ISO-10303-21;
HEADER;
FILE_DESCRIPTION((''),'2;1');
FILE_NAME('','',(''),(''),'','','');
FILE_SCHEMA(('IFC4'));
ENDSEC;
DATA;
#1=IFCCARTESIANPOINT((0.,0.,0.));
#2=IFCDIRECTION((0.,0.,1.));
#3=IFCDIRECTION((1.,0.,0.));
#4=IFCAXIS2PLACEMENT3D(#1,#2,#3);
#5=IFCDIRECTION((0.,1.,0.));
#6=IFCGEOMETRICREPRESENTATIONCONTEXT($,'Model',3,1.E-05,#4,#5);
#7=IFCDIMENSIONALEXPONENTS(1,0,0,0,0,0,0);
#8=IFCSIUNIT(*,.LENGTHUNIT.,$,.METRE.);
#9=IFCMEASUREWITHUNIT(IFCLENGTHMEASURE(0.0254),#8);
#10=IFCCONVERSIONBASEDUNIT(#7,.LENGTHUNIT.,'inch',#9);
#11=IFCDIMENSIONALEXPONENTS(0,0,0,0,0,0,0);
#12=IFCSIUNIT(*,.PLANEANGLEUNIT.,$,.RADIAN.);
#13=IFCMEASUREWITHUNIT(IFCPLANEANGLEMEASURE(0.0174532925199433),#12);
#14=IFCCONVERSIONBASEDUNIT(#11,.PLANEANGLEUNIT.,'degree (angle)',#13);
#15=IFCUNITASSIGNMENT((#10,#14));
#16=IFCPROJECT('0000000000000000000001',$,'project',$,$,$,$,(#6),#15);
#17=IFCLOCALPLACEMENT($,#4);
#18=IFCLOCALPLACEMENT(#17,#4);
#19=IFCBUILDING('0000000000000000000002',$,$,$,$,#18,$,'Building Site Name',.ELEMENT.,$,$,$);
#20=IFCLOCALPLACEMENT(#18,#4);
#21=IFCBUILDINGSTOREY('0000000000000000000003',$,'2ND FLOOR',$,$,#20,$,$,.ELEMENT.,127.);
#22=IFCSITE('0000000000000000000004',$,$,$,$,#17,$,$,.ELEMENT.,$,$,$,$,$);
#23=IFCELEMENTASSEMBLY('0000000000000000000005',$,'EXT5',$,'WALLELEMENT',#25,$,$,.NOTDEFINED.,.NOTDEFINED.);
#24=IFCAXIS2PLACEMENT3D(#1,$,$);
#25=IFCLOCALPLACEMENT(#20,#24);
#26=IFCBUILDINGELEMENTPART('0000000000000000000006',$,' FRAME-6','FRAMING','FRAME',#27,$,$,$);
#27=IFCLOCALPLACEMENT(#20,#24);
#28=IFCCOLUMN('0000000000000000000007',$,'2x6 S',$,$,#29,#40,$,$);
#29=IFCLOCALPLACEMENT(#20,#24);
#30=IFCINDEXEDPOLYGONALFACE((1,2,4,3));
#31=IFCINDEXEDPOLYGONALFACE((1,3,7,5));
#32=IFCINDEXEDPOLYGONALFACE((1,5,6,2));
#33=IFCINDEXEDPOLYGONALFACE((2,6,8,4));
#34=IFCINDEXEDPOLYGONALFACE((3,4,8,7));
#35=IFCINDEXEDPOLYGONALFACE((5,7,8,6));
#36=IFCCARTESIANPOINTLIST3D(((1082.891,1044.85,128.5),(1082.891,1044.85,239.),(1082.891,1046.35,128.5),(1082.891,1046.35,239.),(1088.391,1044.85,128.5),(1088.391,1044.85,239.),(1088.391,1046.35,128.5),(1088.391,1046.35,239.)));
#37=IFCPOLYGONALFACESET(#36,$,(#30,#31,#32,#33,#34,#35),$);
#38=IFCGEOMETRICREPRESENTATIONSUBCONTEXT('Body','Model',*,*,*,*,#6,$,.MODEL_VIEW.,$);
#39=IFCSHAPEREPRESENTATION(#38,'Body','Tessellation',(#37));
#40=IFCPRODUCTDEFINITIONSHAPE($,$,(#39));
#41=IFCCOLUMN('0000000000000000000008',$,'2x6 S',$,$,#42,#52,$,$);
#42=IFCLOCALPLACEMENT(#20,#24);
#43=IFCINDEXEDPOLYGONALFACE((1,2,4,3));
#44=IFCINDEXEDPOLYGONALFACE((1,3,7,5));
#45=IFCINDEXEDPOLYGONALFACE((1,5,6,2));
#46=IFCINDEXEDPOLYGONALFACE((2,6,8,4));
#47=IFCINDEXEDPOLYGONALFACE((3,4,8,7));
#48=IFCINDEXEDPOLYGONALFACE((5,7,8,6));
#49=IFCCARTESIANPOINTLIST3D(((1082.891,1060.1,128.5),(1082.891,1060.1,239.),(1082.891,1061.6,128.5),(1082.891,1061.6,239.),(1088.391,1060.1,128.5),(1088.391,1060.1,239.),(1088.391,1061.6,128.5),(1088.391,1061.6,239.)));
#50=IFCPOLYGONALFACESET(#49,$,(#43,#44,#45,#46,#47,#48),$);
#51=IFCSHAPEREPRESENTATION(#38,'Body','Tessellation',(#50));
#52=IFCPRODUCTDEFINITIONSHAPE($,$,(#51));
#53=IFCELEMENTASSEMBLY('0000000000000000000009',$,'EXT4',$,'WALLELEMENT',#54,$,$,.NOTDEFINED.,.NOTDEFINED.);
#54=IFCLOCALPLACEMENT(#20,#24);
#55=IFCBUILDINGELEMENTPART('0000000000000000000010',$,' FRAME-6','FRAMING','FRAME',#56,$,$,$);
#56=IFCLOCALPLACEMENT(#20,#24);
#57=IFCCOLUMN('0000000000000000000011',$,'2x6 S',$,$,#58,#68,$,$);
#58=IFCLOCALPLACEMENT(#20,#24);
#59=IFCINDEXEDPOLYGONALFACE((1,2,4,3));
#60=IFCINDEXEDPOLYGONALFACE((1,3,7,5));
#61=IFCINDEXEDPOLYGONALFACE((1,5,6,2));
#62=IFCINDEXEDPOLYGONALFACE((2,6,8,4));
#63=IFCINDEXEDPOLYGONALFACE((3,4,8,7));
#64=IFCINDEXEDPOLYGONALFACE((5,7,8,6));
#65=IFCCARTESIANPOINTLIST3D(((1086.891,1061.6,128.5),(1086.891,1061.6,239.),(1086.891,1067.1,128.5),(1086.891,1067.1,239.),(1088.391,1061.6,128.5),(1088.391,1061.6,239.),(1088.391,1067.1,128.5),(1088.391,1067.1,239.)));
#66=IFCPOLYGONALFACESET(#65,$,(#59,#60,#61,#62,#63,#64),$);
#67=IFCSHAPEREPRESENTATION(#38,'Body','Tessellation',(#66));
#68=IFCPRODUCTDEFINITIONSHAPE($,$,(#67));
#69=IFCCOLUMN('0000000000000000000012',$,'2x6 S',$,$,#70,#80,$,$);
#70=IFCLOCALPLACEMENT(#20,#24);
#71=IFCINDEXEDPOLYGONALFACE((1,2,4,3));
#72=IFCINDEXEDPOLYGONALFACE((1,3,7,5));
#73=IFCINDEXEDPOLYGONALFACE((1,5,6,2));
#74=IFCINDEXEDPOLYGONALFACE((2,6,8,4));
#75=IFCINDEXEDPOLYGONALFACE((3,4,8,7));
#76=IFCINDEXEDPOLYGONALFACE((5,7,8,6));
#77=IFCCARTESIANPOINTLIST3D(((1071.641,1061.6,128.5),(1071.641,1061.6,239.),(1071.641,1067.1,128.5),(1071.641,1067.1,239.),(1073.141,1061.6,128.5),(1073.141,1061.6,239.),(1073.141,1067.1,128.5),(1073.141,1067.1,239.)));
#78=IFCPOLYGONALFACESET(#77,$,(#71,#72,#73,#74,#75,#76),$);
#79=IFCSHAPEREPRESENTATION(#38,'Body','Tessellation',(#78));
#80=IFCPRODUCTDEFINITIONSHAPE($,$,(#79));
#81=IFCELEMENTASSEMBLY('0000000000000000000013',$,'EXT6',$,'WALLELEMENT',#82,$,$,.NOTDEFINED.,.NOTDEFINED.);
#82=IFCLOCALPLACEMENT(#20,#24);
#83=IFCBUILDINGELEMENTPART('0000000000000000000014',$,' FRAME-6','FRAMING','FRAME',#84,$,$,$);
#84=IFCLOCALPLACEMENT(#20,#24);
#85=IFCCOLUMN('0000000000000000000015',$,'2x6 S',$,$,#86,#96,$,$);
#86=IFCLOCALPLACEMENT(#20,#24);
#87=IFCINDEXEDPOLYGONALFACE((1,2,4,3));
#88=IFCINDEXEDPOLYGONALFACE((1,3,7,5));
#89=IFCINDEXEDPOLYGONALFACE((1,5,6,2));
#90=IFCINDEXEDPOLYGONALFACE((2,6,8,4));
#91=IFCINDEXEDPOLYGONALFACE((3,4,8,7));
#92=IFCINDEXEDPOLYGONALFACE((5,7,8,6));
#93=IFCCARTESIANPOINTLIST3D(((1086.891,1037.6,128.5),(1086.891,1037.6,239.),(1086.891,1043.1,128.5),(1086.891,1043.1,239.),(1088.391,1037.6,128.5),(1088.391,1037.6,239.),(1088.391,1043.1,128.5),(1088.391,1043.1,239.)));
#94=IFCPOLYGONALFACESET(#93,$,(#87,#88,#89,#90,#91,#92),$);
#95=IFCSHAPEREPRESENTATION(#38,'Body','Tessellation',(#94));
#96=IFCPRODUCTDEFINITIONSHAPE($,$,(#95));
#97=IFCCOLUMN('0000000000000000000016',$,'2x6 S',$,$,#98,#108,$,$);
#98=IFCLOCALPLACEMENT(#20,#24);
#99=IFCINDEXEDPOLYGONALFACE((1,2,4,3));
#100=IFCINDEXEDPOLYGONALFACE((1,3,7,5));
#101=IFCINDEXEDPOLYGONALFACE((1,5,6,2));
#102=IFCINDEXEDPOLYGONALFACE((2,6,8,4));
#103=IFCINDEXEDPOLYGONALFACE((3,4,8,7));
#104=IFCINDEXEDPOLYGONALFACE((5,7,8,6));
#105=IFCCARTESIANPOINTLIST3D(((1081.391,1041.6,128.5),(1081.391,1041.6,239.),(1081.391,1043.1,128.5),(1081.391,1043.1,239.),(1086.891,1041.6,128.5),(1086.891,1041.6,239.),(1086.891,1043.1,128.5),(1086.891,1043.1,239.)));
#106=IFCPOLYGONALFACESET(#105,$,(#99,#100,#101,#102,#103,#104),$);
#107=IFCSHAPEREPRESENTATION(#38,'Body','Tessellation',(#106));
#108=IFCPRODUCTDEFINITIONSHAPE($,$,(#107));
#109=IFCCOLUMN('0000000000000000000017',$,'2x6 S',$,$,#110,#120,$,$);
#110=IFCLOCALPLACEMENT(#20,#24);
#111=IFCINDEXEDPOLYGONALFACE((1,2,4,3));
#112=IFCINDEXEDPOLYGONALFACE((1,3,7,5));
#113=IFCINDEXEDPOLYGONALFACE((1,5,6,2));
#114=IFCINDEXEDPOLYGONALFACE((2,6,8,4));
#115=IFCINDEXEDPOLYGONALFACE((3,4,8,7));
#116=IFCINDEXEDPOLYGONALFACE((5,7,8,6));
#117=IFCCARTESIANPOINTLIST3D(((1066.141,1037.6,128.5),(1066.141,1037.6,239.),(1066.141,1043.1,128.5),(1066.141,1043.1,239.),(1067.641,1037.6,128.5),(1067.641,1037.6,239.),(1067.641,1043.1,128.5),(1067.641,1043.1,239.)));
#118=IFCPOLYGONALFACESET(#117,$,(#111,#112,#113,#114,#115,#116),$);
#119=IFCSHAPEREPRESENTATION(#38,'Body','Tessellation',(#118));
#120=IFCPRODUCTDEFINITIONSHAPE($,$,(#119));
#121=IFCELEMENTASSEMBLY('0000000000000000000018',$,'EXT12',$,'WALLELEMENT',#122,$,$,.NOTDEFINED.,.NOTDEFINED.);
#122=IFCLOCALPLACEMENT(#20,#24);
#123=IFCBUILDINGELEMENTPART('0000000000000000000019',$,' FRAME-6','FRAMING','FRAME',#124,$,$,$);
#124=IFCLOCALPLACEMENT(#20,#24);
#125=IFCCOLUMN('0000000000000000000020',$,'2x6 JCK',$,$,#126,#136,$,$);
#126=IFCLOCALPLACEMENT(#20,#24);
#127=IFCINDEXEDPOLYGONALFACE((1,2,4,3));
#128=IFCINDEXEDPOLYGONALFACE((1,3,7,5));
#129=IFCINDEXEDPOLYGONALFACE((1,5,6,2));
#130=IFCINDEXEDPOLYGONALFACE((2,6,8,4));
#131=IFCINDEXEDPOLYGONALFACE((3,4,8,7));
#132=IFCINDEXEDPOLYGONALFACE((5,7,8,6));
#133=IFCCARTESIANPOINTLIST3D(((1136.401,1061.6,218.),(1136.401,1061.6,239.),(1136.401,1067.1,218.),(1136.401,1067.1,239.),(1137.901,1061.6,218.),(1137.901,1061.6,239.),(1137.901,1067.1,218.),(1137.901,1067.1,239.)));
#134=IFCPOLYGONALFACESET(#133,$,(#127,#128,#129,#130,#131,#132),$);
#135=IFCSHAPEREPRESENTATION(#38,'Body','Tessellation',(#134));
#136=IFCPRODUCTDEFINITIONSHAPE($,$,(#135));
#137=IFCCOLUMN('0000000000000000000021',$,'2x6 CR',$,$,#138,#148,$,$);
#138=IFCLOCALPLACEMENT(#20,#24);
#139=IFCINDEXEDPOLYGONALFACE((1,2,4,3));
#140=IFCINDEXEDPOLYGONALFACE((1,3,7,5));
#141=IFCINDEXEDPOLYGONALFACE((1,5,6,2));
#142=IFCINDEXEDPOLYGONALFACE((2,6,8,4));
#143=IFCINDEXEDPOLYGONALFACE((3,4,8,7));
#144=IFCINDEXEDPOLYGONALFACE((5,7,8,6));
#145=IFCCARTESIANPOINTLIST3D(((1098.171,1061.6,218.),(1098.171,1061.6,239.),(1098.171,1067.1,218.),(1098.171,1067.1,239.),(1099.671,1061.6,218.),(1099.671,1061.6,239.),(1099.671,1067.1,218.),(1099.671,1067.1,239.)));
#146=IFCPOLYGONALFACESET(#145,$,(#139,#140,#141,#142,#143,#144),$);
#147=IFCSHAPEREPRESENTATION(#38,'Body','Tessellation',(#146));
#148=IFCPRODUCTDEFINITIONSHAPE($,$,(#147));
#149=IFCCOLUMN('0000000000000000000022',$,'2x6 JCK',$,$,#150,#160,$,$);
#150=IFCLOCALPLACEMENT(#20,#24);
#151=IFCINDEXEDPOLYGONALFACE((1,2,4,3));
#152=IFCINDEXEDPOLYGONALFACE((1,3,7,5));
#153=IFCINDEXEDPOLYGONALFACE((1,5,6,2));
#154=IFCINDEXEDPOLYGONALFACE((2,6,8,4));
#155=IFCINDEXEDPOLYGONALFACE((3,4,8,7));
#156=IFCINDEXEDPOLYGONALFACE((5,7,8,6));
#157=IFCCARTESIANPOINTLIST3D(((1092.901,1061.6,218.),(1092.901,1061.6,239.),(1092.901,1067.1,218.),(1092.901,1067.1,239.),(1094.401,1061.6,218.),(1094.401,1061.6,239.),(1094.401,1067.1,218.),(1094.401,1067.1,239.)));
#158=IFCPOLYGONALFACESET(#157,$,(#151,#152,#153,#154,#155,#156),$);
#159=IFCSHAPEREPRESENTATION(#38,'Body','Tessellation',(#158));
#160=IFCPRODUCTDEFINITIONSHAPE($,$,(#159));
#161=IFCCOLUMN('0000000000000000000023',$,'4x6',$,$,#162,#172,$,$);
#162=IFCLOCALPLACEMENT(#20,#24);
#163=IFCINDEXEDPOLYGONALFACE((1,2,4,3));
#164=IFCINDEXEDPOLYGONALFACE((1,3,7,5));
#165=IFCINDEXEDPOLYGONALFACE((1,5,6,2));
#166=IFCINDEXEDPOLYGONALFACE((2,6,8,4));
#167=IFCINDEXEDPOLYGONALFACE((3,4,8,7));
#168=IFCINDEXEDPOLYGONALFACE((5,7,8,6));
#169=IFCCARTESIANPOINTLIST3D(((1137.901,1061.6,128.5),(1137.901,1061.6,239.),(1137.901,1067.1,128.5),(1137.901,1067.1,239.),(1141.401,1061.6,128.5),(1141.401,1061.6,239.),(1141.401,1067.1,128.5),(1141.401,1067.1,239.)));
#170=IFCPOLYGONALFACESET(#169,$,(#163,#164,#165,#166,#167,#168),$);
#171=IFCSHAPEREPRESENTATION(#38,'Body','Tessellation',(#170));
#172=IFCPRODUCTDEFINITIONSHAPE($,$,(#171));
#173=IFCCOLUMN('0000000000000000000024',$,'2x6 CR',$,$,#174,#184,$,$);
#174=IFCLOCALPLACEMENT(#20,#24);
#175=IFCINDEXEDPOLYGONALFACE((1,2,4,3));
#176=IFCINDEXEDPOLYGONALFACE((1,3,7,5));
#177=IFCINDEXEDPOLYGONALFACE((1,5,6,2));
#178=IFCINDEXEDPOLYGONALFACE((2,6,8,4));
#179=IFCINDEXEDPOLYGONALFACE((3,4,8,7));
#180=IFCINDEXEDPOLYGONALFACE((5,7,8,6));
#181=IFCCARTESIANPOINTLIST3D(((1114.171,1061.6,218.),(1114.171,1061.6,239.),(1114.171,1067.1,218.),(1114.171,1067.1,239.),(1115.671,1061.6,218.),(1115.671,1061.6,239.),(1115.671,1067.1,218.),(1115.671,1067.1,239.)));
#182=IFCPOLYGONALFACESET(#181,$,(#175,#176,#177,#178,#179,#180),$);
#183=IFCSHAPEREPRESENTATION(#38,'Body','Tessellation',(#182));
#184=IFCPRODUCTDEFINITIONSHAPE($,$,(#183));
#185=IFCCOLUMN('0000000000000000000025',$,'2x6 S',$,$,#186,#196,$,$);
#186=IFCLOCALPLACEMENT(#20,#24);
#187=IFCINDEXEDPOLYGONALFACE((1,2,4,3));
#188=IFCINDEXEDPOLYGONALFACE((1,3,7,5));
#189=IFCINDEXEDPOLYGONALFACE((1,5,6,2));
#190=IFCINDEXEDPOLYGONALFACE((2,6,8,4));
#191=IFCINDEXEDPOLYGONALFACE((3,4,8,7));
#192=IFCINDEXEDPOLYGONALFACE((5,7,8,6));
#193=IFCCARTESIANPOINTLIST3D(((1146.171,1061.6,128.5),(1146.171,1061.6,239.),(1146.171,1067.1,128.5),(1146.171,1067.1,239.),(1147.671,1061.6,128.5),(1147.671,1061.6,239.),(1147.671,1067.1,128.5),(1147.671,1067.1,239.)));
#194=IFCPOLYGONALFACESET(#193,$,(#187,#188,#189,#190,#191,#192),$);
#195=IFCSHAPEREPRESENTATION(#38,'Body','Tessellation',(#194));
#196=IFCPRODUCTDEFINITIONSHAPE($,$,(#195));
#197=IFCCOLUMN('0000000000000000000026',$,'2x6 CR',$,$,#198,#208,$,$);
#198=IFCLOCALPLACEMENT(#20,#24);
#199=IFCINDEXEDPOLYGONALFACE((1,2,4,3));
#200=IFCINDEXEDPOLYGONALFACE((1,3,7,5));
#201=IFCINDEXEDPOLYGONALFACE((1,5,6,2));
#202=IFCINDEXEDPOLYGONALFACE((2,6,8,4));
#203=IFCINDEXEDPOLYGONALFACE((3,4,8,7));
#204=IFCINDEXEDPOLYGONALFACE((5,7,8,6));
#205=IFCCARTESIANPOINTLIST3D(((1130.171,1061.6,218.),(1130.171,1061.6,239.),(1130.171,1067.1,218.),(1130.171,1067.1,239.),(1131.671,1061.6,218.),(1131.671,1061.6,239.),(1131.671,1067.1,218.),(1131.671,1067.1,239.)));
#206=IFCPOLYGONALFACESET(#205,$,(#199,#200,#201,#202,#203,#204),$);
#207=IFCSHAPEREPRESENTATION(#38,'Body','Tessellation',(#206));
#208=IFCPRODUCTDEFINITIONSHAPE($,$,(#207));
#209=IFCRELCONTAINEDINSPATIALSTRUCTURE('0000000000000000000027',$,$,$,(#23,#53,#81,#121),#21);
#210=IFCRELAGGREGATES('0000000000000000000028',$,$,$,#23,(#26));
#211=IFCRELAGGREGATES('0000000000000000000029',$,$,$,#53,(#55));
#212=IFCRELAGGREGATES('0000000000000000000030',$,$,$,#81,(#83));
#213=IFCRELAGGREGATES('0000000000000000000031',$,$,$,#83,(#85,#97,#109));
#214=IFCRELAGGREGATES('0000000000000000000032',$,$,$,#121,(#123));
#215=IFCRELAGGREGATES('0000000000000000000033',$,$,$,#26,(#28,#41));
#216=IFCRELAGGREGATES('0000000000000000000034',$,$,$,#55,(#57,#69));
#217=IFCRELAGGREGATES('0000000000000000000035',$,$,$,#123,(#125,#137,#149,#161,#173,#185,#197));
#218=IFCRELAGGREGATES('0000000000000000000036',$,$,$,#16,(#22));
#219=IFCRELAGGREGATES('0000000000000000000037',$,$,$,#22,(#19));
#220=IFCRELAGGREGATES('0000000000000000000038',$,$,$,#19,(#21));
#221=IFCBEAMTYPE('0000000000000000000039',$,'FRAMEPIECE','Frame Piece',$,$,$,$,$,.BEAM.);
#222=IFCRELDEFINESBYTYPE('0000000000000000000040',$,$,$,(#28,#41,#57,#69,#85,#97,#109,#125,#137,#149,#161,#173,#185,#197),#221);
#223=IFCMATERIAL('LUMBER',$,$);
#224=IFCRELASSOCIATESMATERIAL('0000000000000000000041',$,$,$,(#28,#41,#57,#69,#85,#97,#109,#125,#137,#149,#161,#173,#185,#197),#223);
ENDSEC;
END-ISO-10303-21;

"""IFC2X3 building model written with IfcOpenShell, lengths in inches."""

from ifc_helpers import new_model, entity, si_unit, converted_unit, direction, frame, frame_2d, origin_with_axes, place, context, subcontext, project, spatial, polyline, segment, composite_curve, rectangle, outline, extrude, material, type_object, element, aggregate, save


model = new_model("IFC2X3")

# Units and contexts
model_context = context("Model", 3, precision=1e-05, world=origin_with_axes(), true_north=direction((0.0, 1.0, 0.0)))
body_context = subcontext(model_context, "Body", "Model", "MODEL_VIEW")
ifc_project = project(units=[converted_unit("LENGTHUNIT", "inch", entity("IfcLengthMeasure", 0.0254), si_unit("LENGTHUNIT", "METRE"), dimensions=[1, 0, 0, 0, 0, 0, 0]), converted_unit("PLANEANGLEUNIT", "degree (angle)", entity("IfcPlaneAngleMeasure", 0.0174532925199433), si_unit("PLANEANGLEUNIT", "RADIAN"), dimensions=[0, 0, 0, 0, 0, 0, 0])], contexts=[model_context])

# Site, building, storey
site_placement = place(None, origin_with_axes())
site = spatial("IfcSite", under=ifc_project, at=site_placement, CompositionType="ELEMENT")
building_placement = place(site_placement, origin_with_axes())
building = spatial("IfcBuilding", under=site, at=building_placement, LongName="Building Site Name", CompositionType="ELEMENT")
storey_placement = place(building_placement, origin_with_axes())
storey = spatial("IfcBuildingStorey", under=building, at=storey_placement, Name="2ND FLOOR", CompositionType="ELEMENT", Elevation=127.0)

# Element assemblies, building element parts, columns
assembly_1_placement = place(storey_placement, origin_with_axes())
assembly_1 = element("IfcElementAssembly", 1, at=assembly_1_placement, inside=storey, Name="EXT5", ObjectType="WALLELEMENT", AssemblyPlace="NOTDEFINED", PredefinedType="NOTDEFINED")
building_element_part_1 = element("IfcBuildingElementPart", 2, Name=" FRAME-6", Description="FRAMING", ObjectType="FRAME")
aggregate(assembly_1, [building_element_part_1])
ifc_material = material(Name="LUMBER")
beam_type = type_object("IfcBeamType", Name="FRAMEPIECE", Description="Frame Piece", PredefinedType="BEAM")
column_1_placement = place(assembly_1_placement, frame((1085.641, 1045.6, 239.0), z_axis=(0.0, 0.0, -1.0), x_axis=(0.0, -1.0, 0.0)))
column_1 = element("IfcColumn", 3, at=column_1_placement, type_object=beam_type, material=ifc_material, Name="2x6 S", context=body_context, shape_type="SweptSolid", body=[
    extrude(rectangle(XDim=1.5, YDim=5.5, at=frame_2d((0.0, 0.0), x_axis=(-1.0, 0.0))), origin_with_axes(), (0.0, 0.0, 1.0), 110.5),
])
column_2_placement = place(assembly_1_placement, frame((1085.641, 1060.85, 239.0), z_axis=(0.0, 0.0, -1.0), x_axis=(0.0, -1.0, 0.0)))
column_2 = element("IfcColumn", 4, at=column_2_placement, type_object=beam_type, material=ifc_material, Name="2x6 S", context=body_context, shape_type="SweptSolid", body=[
    extrude(rectangle(XDim=1.5, YDim=5.5, at=frame_2d((0.0, 0.0), x_axis=(-1.0, 0.0))), origin_with_axes(), (0.0, 0.0, 1.0), 110.5),
])
assembly_2_placement = place(storey_placement, origin_with_axes())
assembly_2 = element("IfcElementAssembly", 5, at=assembly_2_placement, inside=storey, Name="EXT4", ObjectType="WALLELEMENT", AssemblyPlace="NOTDEFINED", PredefinedType="NOTDEFINED")
building_element_part_2 = element("IfcBuildingElementPart", 6, Name=" FRAME-6", Description="FRAMING", ObjectType="FRAME")
aggregate(assembly_2, [building_element_part_2])
column_3_placement = place(assembly_2_placement, frame((1087.641, 1064.35, 239.0), z_axis=(0.0, 0.0, -1.0), x_axis=(-1.0, 0.0, 0.0)))
column_3 = element("IfcColumn", 7, at=column_3_placement, type_object=beam_type, material=ifc_material, Name="2x6 S", context=body_context, shape_type="SweptSolid", body=[
    extrude(rectangle(XDim=1.5, YDim=5.5, at=frame_2d((0.0, 0.0), x_axis=(-1.0, 0.0))), origin_with_axes(), (0.0, 0.0, 1.0), 110.5),
])
column_4_placement = place(assembly_2_placement, frame((1072.391, 1064.35, 239.0), z_axis=(0.0, 0.0, -1.0), x_axis=(-1.0, 0.0, 0.0)))
column_4 = element("IfcColumn", 8, at=column_4_placement, type_object=beam_type, material=ifc_material, Name="2x6 S", context=body_context, shape_type="SweptSolid", body=[
    extrude(rectangle(XDim=1.5, YDim=5.5, at=frame_2d((0.0, 0.0), x_axis=(-1.0, 0.0))), origin_with_axes(), (0.0, 0.0, 1.0), 110.5),
])
assembly_3_placement = place(storey_placement, origin_with_axes())
assembly_3 = element("IfcElementAssembly", 9, at=assembly_3_placement, inside=storey, Name="EXT6", ObjectType="WALLELEMENT", AssemblyPlace="NOTDEFINED", PredefinedType="NOTDEFINED")
building_element_part_3 = element("IfcBuildingElementPart", 10, Name=" FRAME-6", Description="FRAMING", ObjectType="FRAME")
aggregate(assembly_3, [building_element_part_3])
column_5_placement = place(assembly_3_placement, frame((1087.641, 1040.35, 239.0), z_axis=(0.0, 0.0, -1.0), x_axis=(-1.0, 0.0, 0.0)))
column_5 = element("IfcColumn", 11, at=column_5_placement, type_object=beam_type, material=ifc_material, Name="2x6 S", context=body_context, shape_type="SweptSolid", body=[
    extrude(rectangle(XDim=1.5, YDim=5.5, at=frame_2d((0.0, 0.0), x_axis=(-1.0, 0.0))), origin_with_axes(), (0.0, 0.0, 1.0), 110.5),
])
column_6_placement = place(assembly_3_placement, frame((1084.141, 1042.35, 239.0), z_axis=(0.0, 0.0, -1.0), x_axis=(0.0, -1.0, 0.0)))
column_6 = element("IfcColumn", 12, at=column_6_placement, type_object=beam_type, material=ifc_material, Name="2x6 S", context=body_context, shape_type="SweptSolid", body=[
    extrude(rectangle(XDim=1.5, YDim=5.5, at=frame_2d((0.0, 0.0), x_axis=(-1.0, 0.0))), origin_with_axes(), (0.0, 0.0, 1.0), 110.5),
])
column_7_placement = place(assembly_3_placement, frame((1066.891, 1040.35, 239.0), z_axis=(0.0, 0.0, -1.0), x_axis=(-1.0, 0.0, 0.0)))
column_7 = element("IfcColumn", 13, at=column_7_placement, type_object=beam_type, material=ifc_material, Name="2x6 S", context=body_context, shape_type="SweptSolid", body=[
    extrude(rectangle(XDim=1.5, YDim=5.5, at=frame_2d((0.0, 0.0), x_axis=(-1.0, 0.0))), origin_with_axes(), (0.0, 0.0, 1.0), 110.5),
])
aggregate(building_element_part_3, [column_5, column_6, column_7])
assembly_4_placement = place(storey_placement, origin_with_axes())
assembly_4 = element("IfcElementAssembly", 14, at=assembly_4_placement, inside=storey, Name="EXT12", ObjectType="WALLELEMENT", AssemblyPlace="NOTDEFINED", PredefinedType="NOTDEFINED")
building_element_part_4 = element("IfcBuildingElementPart", 15, Name=" FRAME-6", Description="FRAMING", ObjectType="FRAME")
aggregate(assembly_4, [building_element_part_4])
column_8_placement = place(assembly_4_placement, frame((1137.151, 1064.35, 239.0), z_axis=(0.0, 0.0, -1.0), x_axis=(-1.0, 0.0, 0.0)))
column_8 = element("IfcColumn", 16, at=column_8_placement, type_object=beam_type, material=ifc_material, Name="2x6 JCK", context=body_context, shape_type="SweptSolid", body=[
    extrude(rectangle(XDim=1.5, YDim=5.5, at=frame_2d((0.0, 0.0), x_axis=(-1.0, 0.0))), origin_with_axes(), (0.0, 0.0, 1.0), 21.0),
])
column_9_placement = place(assembly_4_placement, frame((1098.921, 1064.35, 239.0), z_axis=(0.0, 0.0, -1.0), x_axis=(-1.0, 0.0, 0.0)))
column_9 = element("IfcColumn", 17, at=column_9_placement, type_object=beam_type, material=ifc_material, Name="2x6 CR", context=body_context, shape_type="SweptSolid", body=[
    extrude(rectangle(XDim=1.5, YDim=5.5, at=frame_2d((0.0, 0.0), x_axis=(-1.0, 0.0))), origin_with_axes(), (0.0, 0.0, 1.0), 21.0),
])
column_10_placement = place(assembly_4_placement, frame((1093.651, 1064.35, 218.0), z_axis=(0.0, 0.0, 1.0), x_axis=(1.0, 0.0, 0.0)))
column_10 = element("IfcColumn", 18, at=column_10_placement, type_object=beam_type, material=ifc_material, Name="2x6 JCK", context=body_context, shape_type="SweptSolid", body=[
    extrude(rectangle(XDim=1.5, YDim=5.5, at=frame_2d((0.0, 0.0), x_axis=(-1.0, 0.0))), origin_with_axes(), (0.0, 0.0, 1.0), 21.0),
])
column_11_placement = place(assembly_4_placement, frame((1139.651, 1064.35, 239.0), z_axis=(0.0, 0.0, -1.0), x_axis=(-1.0, 0.0, 0.0)))
column_11 = element("IfcColumn", 19, at=column_11_placement, type_object=beam_type, material=ifc_material, Name="4x6", context=body_context, shape_type="SweptSolid", body=[
    extrude(outline(composite_curve([segment(polyline([(-1.75, -2.75), (-1.75, 2.75), (1.75, 2.75), (1.75, -2.75), (-1.75, -2.75)]), True, "CONTINUOUS")], self_intersect=False)), origin_with_axes(), (0.0, 0.0, 1.0), 110.5),
])
column_12_placement = place(assembly_4_placement, frame((1114.921, 1064.35, 239.0), z_axis=(0.0, 0.0, -1.0), x_axis=(-1.0, 0.0, 0.0)))
column_12 = element("IfcColumn", 20, at=column_12_placement, type_object=beam_type, material=ifc_material, Name="2x6 CR", context=body_context, shape_type="SweptSolid", body=[
    extrude(rectangle(XDim=1.5, YDim=5.5, at=frame_2d((0.0, 0.0), x_axis=(-1.0, 0.0))), origin_with_axes(), (0.0, 0.0, 1.0), 21.0),
])
column_13_placement = place(assembly_4_placement, frame((1146.921, 1064.35, 239.0), z_axis=(0.0, 0.0, -1.0), x_axis=(-1.0, 0.0, 0.0)))
column_13 = element("IfcColumn", 21, at=column_13_placement, type_object=beam_type, material=ifc_material, Name="2x6 S", context=body_context, shape_type="SweptSolid", body=[
    extrude(rectangle(XDim=1.5, YDim=5.5, at=frame_2d((0.0, 0.0), x_axis=(-1.0, 0.0))), origin_with_axes(), (0.0, 0.0, 1.0), 110.5),
])
column_14_placement = place(assembly_4_placement, frame((1130.921, 1064.35, 239.0), z_axis=(0.0, 0.0, -1.0), x_axis=(-1.0, 0.0, 0.0)))
column_14 = element("IfcColumn", 22, at=column_14_placement, type_object=beam_type, material=ifc_material, Name="2x6 CR", context=body_context, shape_type="SweptSolid", body=[
    extrude(rectangle(XDim=1.5, YDim=5.5, at=frame_2d((0.0, 0.0), x_axis=(-1.0, 0.0))), origin_with_axes(), (0.0, 0.0, 1.0), 21.0),
])

aggregate(building_element_part_1, [column_1, column_2])
aggregate(building_element_part_2, [column_3, column_4])
aggregate(building_element_part_4, [column_8, column_9, column_10, column_11, column_12, column_13, column_14])

save(model, "model.ifc")
